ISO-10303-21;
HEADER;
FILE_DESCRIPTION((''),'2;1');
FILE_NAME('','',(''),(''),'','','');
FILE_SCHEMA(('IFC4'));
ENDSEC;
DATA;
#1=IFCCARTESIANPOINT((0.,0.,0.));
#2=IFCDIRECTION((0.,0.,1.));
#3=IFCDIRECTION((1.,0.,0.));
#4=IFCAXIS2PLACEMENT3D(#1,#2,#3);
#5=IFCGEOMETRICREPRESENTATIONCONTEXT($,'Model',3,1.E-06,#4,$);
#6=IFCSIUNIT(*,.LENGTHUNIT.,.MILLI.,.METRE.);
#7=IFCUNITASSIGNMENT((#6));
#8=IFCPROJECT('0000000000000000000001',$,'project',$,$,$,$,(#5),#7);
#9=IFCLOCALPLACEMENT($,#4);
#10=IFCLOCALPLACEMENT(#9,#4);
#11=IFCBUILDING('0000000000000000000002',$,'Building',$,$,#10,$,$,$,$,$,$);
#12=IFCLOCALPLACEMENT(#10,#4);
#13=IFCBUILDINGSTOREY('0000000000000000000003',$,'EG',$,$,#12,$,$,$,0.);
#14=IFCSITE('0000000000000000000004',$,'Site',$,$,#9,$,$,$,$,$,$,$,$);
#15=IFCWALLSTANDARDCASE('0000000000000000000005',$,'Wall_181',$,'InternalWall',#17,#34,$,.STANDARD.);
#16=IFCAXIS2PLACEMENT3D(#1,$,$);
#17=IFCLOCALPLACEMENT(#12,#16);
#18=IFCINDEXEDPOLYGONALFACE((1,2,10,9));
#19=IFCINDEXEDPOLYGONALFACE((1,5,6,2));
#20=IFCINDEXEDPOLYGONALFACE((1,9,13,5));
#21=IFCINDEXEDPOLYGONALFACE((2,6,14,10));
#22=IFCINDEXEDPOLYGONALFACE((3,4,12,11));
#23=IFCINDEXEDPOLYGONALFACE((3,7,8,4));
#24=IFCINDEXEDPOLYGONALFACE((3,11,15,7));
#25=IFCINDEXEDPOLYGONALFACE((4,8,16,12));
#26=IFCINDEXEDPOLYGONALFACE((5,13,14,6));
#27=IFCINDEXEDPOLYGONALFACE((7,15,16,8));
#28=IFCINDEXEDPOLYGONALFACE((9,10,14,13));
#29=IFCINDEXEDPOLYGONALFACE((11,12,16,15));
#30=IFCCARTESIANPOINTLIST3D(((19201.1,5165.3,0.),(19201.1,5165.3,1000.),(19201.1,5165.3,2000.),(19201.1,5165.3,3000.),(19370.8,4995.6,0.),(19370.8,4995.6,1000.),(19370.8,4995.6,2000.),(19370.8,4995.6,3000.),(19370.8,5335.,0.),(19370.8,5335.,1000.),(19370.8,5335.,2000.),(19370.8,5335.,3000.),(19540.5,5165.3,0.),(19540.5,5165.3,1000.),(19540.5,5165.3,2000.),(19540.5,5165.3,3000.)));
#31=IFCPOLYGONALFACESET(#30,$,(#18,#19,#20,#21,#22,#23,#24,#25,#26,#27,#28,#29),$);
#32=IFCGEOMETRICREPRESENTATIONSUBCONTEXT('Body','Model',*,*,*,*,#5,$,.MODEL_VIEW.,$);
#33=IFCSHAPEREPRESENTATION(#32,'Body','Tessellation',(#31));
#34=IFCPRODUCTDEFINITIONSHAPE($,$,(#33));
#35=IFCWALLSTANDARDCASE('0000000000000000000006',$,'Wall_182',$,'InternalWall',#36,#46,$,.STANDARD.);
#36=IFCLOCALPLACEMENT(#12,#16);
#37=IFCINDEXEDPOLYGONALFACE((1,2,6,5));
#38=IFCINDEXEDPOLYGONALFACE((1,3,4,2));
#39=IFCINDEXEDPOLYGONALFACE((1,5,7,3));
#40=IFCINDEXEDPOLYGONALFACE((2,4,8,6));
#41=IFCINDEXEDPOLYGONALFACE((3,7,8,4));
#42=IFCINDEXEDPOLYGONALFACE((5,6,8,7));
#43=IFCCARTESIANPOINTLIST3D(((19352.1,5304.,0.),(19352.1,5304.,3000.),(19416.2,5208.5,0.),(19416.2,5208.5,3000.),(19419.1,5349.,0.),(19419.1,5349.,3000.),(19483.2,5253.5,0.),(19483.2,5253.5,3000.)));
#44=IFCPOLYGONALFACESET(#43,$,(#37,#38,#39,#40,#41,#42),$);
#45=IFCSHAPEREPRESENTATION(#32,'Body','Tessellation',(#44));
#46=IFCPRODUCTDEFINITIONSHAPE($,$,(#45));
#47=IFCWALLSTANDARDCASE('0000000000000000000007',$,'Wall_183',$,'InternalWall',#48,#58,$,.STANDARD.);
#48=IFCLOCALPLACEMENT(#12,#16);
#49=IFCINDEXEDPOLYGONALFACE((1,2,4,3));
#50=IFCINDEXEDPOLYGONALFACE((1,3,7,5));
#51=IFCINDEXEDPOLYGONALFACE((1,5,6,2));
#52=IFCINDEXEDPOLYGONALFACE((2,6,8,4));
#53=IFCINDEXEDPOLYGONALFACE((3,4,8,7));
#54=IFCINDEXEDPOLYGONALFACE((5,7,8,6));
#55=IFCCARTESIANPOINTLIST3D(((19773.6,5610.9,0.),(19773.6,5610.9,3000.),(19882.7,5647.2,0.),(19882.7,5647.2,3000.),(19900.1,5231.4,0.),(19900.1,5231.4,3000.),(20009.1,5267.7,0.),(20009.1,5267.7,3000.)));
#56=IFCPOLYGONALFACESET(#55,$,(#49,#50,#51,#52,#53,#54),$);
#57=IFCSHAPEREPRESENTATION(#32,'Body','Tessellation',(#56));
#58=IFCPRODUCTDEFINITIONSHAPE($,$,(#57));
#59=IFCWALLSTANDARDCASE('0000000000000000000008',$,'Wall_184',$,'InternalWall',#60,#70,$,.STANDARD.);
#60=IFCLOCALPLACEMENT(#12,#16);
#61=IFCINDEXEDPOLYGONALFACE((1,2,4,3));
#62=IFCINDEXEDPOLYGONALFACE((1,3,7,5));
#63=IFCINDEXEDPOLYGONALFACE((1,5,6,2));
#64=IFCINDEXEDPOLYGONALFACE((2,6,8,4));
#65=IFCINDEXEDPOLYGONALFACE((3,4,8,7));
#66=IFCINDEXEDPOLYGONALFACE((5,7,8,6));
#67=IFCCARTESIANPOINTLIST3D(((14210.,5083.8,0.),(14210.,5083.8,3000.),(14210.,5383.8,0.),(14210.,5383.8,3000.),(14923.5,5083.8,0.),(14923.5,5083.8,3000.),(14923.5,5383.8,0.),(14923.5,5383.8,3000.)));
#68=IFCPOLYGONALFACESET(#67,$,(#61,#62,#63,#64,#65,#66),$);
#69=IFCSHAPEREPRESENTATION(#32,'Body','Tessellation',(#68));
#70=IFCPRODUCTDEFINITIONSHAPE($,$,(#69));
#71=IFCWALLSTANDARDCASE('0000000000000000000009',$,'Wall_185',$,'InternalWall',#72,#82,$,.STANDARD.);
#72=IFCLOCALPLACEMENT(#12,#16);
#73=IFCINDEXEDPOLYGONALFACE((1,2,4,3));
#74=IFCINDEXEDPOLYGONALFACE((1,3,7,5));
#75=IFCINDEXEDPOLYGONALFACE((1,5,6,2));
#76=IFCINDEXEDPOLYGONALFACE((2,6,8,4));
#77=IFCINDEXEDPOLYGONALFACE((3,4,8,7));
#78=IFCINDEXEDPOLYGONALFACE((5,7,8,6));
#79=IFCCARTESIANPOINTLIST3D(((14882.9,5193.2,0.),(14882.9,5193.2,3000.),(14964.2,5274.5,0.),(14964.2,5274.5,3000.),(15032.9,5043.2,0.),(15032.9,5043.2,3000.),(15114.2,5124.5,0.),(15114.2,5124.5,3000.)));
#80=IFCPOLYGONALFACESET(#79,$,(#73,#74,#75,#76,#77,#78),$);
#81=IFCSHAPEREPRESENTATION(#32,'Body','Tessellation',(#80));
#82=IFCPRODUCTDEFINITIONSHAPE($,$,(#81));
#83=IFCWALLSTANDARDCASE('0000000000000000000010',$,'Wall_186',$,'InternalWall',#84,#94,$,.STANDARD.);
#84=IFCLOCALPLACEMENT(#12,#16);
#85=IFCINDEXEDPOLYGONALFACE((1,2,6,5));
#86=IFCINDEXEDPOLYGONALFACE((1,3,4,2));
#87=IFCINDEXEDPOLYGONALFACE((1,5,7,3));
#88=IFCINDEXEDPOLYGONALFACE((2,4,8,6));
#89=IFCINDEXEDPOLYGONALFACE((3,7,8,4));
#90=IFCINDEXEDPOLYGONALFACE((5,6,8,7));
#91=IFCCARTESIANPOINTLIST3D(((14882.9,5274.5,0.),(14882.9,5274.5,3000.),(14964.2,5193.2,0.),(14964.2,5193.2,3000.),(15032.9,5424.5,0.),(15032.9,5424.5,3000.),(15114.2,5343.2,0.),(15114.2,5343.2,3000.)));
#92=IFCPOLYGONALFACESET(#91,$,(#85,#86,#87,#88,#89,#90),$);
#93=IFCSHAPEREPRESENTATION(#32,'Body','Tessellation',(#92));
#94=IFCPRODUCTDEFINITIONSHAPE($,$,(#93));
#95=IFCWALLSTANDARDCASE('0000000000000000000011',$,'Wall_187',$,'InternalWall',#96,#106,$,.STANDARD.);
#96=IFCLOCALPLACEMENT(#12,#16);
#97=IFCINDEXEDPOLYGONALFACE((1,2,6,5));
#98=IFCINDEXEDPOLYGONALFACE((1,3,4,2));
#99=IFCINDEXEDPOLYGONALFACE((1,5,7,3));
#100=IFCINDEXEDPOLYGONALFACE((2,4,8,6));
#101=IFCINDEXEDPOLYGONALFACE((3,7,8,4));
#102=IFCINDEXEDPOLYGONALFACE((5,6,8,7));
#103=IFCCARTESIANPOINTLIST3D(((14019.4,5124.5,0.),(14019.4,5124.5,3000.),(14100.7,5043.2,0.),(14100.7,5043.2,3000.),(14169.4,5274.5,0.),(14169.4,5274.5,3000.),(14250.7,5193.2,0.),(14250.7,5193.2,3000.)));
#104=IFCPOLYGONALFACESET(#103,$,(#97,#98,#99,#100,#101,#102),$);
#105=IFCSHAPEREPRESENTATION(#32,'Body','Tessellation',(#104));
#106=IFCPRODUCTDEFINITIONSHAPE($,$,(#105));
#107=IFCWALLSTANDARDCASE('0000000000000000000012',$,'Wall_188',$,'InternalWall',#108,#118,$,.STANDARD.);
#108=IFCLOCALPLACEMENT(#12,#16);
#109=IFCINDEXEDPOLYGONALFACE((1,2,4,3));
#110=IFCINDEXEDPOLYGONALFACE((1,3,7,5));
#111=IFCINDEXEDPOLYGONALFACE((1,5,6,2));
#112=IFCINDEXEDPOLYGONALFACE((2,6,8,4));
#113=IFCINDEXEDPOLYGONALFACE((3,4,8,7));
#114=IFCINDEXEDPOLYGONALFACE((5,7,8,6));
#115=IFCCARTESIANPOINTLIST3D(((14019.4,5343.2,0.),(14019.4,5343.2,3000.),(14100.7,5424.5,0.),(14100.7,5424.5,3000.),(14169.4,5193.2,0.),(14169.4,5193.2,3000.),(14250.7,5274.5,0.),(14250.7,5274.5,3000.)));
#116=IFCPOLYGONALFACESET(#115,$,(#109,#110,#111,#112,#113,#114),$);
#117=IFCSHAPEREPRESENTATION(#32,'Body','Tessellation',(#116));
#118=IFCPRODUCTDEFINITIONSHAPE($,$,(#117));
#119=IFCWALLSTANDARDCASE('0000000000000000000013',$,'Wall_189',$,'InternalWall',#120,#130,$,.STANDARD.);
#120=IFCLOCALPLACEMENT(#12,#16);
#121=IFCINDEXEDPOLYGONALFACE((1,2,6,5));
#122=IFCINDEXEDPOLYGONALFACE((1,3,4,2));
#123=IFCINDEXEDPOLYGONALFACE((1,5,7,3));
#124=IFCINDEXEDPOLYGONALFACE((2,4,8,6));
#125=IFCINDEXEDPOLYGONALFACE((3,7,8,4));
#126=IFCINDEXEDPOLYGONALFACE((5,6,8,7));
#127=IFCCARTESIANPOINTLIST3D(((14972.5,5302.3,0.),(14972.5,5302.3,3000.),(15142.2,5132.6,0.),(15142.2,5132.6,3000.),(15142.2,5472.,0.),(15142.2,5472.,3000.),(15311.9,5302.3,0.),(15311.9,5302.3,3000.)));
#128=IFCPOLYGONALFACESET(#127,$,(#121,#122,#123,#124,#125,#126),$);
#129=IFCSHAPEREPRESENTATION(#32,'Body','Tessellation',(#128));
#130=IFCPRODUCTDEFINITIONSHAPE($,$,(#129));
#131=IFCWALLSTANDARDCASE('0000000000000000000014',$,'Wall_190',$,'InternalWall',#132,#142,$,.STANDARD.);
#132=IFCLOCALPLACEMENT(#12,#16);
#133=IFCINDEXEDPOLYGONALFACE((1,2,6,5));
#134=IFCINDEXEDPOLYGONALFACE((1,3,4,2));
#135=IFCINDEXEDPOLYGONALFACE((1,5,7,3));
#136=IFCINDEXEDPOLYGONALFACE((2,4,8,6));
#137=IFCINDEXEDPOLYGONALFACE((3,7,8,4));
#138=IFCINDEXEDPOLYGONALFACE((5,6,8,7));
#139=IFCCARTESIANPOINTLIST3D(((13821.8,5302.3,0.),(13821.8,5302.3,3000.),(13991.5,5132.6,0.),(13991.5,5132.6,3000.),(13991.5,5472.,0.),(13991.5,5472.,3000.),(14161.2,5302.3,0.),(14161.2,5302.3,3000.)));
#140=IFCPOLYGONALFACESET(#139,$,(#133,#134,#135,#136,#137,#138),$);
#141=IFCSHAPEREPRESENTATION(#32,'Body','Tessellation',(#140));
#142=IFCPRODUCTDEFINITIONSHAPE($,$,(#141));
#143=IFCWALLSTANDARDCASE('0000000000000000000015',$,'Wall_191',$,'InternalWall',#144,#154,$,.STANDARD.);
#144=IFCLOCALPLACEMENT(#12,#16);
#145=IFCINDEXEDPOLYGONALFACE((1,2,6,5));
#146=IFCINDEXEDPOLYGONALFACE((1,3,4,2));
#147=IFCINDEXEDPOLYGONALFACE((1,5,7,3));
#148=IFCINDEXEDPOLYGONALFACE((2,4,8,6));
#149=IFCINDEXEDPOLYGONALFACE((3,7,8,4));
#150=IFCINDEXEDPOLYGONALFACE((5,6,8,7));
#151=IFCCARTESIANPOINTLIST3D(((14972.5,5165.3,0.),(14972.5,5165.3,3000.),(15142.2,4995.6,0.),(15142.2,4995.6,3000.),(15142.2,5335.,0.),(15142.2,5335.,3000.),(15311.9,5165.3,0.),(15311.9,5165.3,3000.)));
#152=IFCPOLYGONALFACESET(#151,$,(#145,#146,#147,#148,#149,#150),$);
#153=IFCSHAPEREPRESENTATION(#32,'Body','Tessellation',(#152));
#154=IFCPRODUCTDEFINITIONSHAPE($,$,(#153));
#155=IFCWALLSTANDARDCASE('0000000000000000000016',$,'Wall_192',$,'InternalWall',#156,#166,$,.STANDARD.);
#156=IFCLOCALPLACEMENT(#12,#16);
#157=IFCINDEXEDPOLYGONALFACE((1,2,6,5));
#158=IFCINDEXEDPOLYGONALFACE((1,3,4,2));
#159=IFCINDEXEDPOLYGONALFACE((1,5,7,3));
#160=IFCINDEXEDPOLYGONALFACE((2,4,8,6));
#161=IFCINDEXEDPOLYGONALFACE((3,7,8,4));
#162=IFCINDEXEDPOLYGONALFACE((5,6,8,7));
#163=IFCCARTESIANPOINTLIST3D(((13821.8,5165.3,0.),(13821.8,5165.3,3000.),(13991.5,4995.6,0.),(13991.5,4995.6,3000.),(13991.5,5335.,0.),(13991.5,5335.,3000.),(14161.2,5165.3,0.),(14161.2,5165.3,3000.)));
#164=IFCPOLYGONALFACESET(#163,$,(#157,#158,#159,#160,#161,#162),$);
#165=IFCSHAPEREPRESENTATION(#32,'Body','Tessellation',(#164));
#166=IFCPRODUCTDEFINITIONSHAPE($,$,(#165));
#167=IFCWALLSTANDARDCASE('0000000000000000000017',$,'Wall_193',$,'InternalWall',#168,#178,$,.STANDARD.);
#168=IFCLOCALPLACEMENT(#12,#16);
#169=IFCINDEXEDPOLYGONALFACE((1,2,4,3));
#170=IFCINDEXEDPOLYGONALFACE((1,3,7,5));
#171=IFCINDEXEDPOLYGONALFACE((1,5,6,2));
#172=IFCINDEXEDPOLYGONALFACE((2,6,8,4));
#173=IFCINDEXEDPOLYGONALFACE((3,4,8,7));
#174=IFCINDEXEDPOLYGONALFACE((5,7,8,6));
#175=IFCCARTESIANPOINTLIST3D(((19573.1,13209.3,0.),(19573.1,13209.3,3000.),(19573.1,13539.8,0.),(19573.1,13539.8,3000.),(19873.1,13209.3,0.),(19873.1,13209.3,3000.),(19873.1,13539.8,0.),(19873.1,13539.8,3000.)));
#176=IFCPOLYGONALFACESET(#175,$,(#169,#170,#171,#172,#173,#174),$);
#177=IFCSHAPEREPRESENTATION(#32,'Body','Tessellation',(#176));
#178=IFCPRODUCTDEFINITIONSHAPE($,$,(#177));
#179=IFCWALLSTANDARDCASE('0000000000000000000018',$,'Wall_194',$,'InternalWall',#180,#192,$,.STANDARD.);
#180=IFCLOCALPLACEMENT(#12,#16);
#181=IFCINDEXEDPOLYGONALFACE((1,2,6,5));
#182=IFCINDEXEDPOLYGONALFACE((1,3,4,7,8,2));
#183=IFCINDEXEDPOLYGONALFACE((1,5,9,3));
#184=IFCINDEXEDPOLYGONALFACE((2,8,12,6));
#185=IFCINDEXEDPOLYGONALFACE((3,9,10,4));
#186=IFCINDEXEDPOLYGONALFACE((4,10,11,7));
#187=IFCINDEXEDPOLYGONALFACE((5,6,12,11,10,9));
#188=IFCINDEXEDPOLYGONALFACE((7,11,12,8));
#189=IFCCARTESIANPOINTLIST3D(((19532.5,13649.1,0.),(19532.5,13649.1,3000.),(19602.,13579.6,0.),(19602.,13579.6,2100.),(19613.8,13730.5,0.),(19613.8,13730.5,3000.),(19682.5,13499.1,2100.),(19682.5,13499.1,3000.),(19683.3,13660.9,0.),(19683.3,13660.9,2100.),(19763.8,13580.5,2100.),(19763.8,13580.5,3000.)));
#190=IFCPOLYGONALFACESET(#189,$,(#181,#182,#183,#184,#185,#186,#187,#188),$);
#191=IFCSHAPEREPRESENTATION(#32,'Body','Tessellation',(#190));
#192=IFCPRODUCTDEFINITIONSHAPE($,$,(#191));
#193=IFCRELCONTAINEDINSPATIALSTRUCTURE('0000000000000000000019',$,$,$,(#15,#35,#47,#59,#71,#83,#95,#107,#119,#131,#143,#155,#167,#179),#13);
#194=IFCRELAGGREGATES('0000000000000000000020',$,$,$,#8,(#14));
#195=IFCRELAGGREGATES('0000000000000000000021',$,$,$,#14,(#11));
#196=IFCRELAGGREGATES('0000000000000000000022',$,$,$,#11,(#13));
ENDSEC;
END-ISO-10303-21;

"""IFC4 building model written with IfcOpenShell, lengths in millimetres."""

from ifc_helpers import new_model, si_unit, frame, origin_with_axes, place, context, subcontext, project, spatial, rectangle, extrude, element, save


model = new_model("IFC4")

# Units and contexts
model_context = context("Model", 3, precision=1e-06, world=origin_with_axes())
body_context = subcontext(model_context, "Body", "Model", "MODEL_VIEW")
ifc_project = project(units=[si_unit("LENGTHUNIT", "METRE", prefix="MILLI")], contexts=[model_context])

# Site, building, storey
site_placement = place(None, origin_with_axes())
site = spatial("IfcSite", under=ifc_project, at=site_placement, Name="Site")
building_placement = place(site_placement, origin_with_axes())
building = spatial("IfcBuilding", under=site, at=building_placement, Name="Building")
storey_placement = place(building_placement, origin_with_axes())
storey = spatial("IfcBuildingStorey", under=building, at=storey_placement, Name="EG", Elevation=0.0)

# Wall, opening
wall_1_placement = place(storey_placement, origin_with_axes())
wall_1 = element("IfcWallStandardCase", 1, at=wall_1_placement, inside=storey, Name="Wall_181", ObjectType="InternalWall", PredefinedType="STANDARD", context=body_context, shape_type="SweptSolid", body=[
    extrude(rectangle(XDim=240.0, YDim=240.0), frame((19370.8, 5165.3, 0.0), z_axis=(0.0, 0.0, 1.0), x_axis=(-0.707107, 0.707107, 0.0)), (0.0, 0.0, 1.0), 3000.0),
])
opening_1_placement = place(wall_1_placement, origin_with_axes())
element("IfcOpeningElement", 2, at=opening_1_placement, inside=storey, cuts=wall_1, context=body_context, shape_type="SweptSolid", body=[
    extrude(rectangle(XDim=600.0, YDim=240.0), frame((19370.8, 5165.3, 1000.0), z_axis=(0.0, 0.0, 1.0), x_axis=(-0.707107, 0.707107, 0.0)), (0.0, 0.0, 1.0), 1000.0),
])

# Walls
wall_2_placement = place(storey_placement, origin_with_axes())
element("IfcWallStandardCase", 3, at=wall_2_placement, inside=storey, Name="Wall_182", ObjectType="InternalWall", PredefinedType="STANDARD", context=body_context, shape_type="SweptSolid", body=[
    extrude(rectangle(XDim=80.7, YDim=115.0), frame((19417.7, 5278.8, 0.0), z_axis=(0.0, 0.0, 1.0), x_axis=(-0.830139, -0.557556, 0.0)), (0.0, 0.0, 1.0), 3000.0),
])
wall_3_placement = place(storey_placement, origin_with_axes())
element("IfcWallStandardCase", 4, at=wall_3_placement, inside=storey, Name="Wall_183", ObjectType="InternalWall", PredefinedType="STANDARD", context=body_context, shape_type="SweptSolid", body=[
    extrude(rectangle(XDim=400.0, YDim=115.0), frame((19891.4, 5439.3, 0.0), z_axis=(0.0, 0.0, 1.0), x_axis=(-0.316228, 0.948683, 0.0)), (0.0, 0.0, 1.0), 3000.0),
])
wall_4_placement = place(storey_placement, origin_with_axes())
element("IfcWallStandardCase", 5, at=wall_4_placement, inside=storey, Name="Wall_184", ObjectType="InternalWall", PredefinedType="STANDARD", context=body_context, shape_type="SweptSolid", body=[
    extrude(rectangle(XDim=713.5, YDim=300.0), frame((14566.8, 5233.8, 0.0), z_axis=(0.0, 0.0, 1.0), x_axis=(-1.0, 0.0, 0.0)), (0.0, 0.0, 1.0), 3000.0),
])
wall_5_placement = place(storey_placement, origin_with_axes())
element("IfcWallStandardCase", 6, at=wall_5_placement, inside=storey, Name="Wall_185", ObjectType="InternalWall", PredefinedType="STANDARD", context=body_context, shape_type="SweptSolid", body=[
    extrude(rectangle(XDim=212.1, YDim=115.0), frame((14998.5, 5158.8, 0.0), z_axis=(0.0, 0.0, 1.0), x_axis=(0.707107, -0.707107, 0.0)), (0.0, 0.0, 1.0), 3000.0),
])
wall_6_placement = place(storey_placement, origin_with_axes())
element("IfcWallStandardCase", 7, at=wall_6_placement, inside=storey, Name="Wall_186", ObjectType="InternalWall", PredefinedType="STANDARD", context=body_context, shape_type="SweptSolid", body=[
    extrude(rectangle(XDim=212.1, YDim=115.0), frame((14998.5, 5308.8, 0.0), z_axis=(0.0, 0.0, 1.0), x_axis=(0.707107, 0.707107, 0.0)), (0.0, 0.0, 1.0), 3000.0),
])
wall_7_placement = place(storey_placement, origin_with_axes())
element("IfcWallStandardCase", 8, at=wall_7_placement, inside=storey, Name="Wall_187", ObjectType="InternalWall", PredefinedType="STANDARD", context=body_context, shape_type="SweptSolid", body=[
    extrude(rectangle(XDim=212.1, YDim=115.0), frame((14135.0, 5158.8, 0.0), z_axis=(0.0, 0.0, 1.0), x_axis=(-0.707107, -0.707107, 0.0)), (0.0, 0.0, 1.0), 3000.0),
])
wall_8_placement = place(storey_placement, origin_with_axes())
element("IfcWallStandardCase", 9, at=wall_8_placement, inside=storey, Name="Wall_188", ObjectType="InternalWall", PredefinedType="STANDARD", context=body_context, shape_type="SweptSolid", body=[
    extrude(rectangle(XDim=212.1, YDim=115.0), frame((14135.0, 5308.8, 0.0), z_axis=(0.0, 0.0, 1.0), x_axis=(-0.707107, 0.707107, 0.0)), (0.0, 0.0, 1.0), 3000.0),
])
wall_9_placement = place(storey_placement, origin_with_axes())
element("IfcWallStandardCase", 10, at=wall_9_placement, inside=storey, Name="Wall_189", ObjectType="InternalWall", PredefinedType="STANDARD", context=body_context, shape_type="SweptSolid", body=[
    extrude(rectangle(XDim=240.0, YDim=240.0), frame((15142.2, 5302.3, 0.0), z_axis=(0.0, 0.0, 1.0), x_axis=(-0.707107, 0.707107, 0.0)), (0.0, 0.0, 1.0), 3000.0),
])
wall_10_placement = place(storey_placement, origin_with_axes())
element("IfcWallStandardCase", 11, at=wall_10_placement, inside=storey, Name="Wall_190", ObjectType="InternalWall", PredefinedType="STANDARD", context=body_context, shape_type="SweptSolid", body=[
    extrude(rectangle(XDim=240.0, YDim=240.0), frame((13991.5, 5302.3, 0.0), z_axis=(0.0, 0.0, 1.0), x_axis=(-0.707107, -0.707107, 0.0)), (0.0, 0.0, 1.0), 3000.0),
])
wall_11_placement = place(storey_placement, origin_with_axes())
element("IfcWallStandardCase", 12, at=wall_11_placement, inside=storey, Name="Wall_191", ObjectType="InternalWall", PredefinedType="STANDARD", context=body_context, shape_type="SweptSolid", body=[
    extrude(rectangle(XDim=240.0, YDim=240.0), frame((15142.2, 5165.3, 0.0), z_axis=(0.0, 0.0, 1.0), x_axis=(0.707107, 0.707107, 0.0)), (0.0, 0.0, 1.0), 3000.0),
])
wall_12_placement = place(storey_placement, origin_with_axes())
element("IfcWallStandardCase", 13, at=wall_12_placement, inside=storey, Name="Wall_192", ObjectType="InternalWall", PredefinedType="STANDARD", context=body_context, shape_type="SweptSolid", body=[
    extrude(rectangle(XDim=240.0, YDim=240.0), frame((13991.5, 5165.3, 0.0), z_axis=(0.0, 0.0, 1.0), x_axis=(0.707107, -0.707107, 0.0)), (0.0, 0.0, 1.0), 3000.0),
])
wall_13_placement = place(storey_placement, origin_with_axes())
element("IfcWallStandardCase", 14, at=wall_13_placement, inside=storey, Name="Wall_193", ObjectType="InternalWall", PredefinedType="STANDARD", context=body_context, shape_type="SweptSolid", body=[
    extrude(rectangle(XDim=330.5, YDim=300.0), frame((19723.1, 13374.5, 0.0), z_axis=(0.0, 0.0, 1.0), x_axis=(0.0, -1.0, 0.0)), (0.0, 0.0, 1.0), 3000.0),
])

# Wall, opening
wall_14_placement = place(storey_placement, origin_with_axes())
wall_14 = element("IfcWallStandardCase", 15, at=wall_14_placement, inside=storey, Name="Wall_194", ObjectType="InternalWall", PredefinedType="STANDARD", context=body_context, shape_type="SweptSolid", body=[
    extrude(rectangle(XDim=212.1, YDim=115.0), frame((19648.1, 13614.8, 0.0), z_axis=(0.0, 0.0, 1.0), x_axis=(0.707107, -0.707107, 0.0)), (0.0, 0.0, 1.0), 3000.0),
])
opening_2_placement = place(wall_14_placement, origin_with_axes())
element("IfcOpeningElement", 16, at=opening_2_placement, inside=storey, cuts=wall_14, context=body_context, shape_type="SweptSolid", body=[
    extrude(rectangle(XDim=781.8, YDim=115.0), frame((19919.1, 13343.8, 0.0), z_axis=(0.0, 0.0, 1.0), x_axis=(0.707107, -0.707107, 0.0)), (0.0, 0.0, 1.0), 2100.0),
])

save(model, "model.ifc")
